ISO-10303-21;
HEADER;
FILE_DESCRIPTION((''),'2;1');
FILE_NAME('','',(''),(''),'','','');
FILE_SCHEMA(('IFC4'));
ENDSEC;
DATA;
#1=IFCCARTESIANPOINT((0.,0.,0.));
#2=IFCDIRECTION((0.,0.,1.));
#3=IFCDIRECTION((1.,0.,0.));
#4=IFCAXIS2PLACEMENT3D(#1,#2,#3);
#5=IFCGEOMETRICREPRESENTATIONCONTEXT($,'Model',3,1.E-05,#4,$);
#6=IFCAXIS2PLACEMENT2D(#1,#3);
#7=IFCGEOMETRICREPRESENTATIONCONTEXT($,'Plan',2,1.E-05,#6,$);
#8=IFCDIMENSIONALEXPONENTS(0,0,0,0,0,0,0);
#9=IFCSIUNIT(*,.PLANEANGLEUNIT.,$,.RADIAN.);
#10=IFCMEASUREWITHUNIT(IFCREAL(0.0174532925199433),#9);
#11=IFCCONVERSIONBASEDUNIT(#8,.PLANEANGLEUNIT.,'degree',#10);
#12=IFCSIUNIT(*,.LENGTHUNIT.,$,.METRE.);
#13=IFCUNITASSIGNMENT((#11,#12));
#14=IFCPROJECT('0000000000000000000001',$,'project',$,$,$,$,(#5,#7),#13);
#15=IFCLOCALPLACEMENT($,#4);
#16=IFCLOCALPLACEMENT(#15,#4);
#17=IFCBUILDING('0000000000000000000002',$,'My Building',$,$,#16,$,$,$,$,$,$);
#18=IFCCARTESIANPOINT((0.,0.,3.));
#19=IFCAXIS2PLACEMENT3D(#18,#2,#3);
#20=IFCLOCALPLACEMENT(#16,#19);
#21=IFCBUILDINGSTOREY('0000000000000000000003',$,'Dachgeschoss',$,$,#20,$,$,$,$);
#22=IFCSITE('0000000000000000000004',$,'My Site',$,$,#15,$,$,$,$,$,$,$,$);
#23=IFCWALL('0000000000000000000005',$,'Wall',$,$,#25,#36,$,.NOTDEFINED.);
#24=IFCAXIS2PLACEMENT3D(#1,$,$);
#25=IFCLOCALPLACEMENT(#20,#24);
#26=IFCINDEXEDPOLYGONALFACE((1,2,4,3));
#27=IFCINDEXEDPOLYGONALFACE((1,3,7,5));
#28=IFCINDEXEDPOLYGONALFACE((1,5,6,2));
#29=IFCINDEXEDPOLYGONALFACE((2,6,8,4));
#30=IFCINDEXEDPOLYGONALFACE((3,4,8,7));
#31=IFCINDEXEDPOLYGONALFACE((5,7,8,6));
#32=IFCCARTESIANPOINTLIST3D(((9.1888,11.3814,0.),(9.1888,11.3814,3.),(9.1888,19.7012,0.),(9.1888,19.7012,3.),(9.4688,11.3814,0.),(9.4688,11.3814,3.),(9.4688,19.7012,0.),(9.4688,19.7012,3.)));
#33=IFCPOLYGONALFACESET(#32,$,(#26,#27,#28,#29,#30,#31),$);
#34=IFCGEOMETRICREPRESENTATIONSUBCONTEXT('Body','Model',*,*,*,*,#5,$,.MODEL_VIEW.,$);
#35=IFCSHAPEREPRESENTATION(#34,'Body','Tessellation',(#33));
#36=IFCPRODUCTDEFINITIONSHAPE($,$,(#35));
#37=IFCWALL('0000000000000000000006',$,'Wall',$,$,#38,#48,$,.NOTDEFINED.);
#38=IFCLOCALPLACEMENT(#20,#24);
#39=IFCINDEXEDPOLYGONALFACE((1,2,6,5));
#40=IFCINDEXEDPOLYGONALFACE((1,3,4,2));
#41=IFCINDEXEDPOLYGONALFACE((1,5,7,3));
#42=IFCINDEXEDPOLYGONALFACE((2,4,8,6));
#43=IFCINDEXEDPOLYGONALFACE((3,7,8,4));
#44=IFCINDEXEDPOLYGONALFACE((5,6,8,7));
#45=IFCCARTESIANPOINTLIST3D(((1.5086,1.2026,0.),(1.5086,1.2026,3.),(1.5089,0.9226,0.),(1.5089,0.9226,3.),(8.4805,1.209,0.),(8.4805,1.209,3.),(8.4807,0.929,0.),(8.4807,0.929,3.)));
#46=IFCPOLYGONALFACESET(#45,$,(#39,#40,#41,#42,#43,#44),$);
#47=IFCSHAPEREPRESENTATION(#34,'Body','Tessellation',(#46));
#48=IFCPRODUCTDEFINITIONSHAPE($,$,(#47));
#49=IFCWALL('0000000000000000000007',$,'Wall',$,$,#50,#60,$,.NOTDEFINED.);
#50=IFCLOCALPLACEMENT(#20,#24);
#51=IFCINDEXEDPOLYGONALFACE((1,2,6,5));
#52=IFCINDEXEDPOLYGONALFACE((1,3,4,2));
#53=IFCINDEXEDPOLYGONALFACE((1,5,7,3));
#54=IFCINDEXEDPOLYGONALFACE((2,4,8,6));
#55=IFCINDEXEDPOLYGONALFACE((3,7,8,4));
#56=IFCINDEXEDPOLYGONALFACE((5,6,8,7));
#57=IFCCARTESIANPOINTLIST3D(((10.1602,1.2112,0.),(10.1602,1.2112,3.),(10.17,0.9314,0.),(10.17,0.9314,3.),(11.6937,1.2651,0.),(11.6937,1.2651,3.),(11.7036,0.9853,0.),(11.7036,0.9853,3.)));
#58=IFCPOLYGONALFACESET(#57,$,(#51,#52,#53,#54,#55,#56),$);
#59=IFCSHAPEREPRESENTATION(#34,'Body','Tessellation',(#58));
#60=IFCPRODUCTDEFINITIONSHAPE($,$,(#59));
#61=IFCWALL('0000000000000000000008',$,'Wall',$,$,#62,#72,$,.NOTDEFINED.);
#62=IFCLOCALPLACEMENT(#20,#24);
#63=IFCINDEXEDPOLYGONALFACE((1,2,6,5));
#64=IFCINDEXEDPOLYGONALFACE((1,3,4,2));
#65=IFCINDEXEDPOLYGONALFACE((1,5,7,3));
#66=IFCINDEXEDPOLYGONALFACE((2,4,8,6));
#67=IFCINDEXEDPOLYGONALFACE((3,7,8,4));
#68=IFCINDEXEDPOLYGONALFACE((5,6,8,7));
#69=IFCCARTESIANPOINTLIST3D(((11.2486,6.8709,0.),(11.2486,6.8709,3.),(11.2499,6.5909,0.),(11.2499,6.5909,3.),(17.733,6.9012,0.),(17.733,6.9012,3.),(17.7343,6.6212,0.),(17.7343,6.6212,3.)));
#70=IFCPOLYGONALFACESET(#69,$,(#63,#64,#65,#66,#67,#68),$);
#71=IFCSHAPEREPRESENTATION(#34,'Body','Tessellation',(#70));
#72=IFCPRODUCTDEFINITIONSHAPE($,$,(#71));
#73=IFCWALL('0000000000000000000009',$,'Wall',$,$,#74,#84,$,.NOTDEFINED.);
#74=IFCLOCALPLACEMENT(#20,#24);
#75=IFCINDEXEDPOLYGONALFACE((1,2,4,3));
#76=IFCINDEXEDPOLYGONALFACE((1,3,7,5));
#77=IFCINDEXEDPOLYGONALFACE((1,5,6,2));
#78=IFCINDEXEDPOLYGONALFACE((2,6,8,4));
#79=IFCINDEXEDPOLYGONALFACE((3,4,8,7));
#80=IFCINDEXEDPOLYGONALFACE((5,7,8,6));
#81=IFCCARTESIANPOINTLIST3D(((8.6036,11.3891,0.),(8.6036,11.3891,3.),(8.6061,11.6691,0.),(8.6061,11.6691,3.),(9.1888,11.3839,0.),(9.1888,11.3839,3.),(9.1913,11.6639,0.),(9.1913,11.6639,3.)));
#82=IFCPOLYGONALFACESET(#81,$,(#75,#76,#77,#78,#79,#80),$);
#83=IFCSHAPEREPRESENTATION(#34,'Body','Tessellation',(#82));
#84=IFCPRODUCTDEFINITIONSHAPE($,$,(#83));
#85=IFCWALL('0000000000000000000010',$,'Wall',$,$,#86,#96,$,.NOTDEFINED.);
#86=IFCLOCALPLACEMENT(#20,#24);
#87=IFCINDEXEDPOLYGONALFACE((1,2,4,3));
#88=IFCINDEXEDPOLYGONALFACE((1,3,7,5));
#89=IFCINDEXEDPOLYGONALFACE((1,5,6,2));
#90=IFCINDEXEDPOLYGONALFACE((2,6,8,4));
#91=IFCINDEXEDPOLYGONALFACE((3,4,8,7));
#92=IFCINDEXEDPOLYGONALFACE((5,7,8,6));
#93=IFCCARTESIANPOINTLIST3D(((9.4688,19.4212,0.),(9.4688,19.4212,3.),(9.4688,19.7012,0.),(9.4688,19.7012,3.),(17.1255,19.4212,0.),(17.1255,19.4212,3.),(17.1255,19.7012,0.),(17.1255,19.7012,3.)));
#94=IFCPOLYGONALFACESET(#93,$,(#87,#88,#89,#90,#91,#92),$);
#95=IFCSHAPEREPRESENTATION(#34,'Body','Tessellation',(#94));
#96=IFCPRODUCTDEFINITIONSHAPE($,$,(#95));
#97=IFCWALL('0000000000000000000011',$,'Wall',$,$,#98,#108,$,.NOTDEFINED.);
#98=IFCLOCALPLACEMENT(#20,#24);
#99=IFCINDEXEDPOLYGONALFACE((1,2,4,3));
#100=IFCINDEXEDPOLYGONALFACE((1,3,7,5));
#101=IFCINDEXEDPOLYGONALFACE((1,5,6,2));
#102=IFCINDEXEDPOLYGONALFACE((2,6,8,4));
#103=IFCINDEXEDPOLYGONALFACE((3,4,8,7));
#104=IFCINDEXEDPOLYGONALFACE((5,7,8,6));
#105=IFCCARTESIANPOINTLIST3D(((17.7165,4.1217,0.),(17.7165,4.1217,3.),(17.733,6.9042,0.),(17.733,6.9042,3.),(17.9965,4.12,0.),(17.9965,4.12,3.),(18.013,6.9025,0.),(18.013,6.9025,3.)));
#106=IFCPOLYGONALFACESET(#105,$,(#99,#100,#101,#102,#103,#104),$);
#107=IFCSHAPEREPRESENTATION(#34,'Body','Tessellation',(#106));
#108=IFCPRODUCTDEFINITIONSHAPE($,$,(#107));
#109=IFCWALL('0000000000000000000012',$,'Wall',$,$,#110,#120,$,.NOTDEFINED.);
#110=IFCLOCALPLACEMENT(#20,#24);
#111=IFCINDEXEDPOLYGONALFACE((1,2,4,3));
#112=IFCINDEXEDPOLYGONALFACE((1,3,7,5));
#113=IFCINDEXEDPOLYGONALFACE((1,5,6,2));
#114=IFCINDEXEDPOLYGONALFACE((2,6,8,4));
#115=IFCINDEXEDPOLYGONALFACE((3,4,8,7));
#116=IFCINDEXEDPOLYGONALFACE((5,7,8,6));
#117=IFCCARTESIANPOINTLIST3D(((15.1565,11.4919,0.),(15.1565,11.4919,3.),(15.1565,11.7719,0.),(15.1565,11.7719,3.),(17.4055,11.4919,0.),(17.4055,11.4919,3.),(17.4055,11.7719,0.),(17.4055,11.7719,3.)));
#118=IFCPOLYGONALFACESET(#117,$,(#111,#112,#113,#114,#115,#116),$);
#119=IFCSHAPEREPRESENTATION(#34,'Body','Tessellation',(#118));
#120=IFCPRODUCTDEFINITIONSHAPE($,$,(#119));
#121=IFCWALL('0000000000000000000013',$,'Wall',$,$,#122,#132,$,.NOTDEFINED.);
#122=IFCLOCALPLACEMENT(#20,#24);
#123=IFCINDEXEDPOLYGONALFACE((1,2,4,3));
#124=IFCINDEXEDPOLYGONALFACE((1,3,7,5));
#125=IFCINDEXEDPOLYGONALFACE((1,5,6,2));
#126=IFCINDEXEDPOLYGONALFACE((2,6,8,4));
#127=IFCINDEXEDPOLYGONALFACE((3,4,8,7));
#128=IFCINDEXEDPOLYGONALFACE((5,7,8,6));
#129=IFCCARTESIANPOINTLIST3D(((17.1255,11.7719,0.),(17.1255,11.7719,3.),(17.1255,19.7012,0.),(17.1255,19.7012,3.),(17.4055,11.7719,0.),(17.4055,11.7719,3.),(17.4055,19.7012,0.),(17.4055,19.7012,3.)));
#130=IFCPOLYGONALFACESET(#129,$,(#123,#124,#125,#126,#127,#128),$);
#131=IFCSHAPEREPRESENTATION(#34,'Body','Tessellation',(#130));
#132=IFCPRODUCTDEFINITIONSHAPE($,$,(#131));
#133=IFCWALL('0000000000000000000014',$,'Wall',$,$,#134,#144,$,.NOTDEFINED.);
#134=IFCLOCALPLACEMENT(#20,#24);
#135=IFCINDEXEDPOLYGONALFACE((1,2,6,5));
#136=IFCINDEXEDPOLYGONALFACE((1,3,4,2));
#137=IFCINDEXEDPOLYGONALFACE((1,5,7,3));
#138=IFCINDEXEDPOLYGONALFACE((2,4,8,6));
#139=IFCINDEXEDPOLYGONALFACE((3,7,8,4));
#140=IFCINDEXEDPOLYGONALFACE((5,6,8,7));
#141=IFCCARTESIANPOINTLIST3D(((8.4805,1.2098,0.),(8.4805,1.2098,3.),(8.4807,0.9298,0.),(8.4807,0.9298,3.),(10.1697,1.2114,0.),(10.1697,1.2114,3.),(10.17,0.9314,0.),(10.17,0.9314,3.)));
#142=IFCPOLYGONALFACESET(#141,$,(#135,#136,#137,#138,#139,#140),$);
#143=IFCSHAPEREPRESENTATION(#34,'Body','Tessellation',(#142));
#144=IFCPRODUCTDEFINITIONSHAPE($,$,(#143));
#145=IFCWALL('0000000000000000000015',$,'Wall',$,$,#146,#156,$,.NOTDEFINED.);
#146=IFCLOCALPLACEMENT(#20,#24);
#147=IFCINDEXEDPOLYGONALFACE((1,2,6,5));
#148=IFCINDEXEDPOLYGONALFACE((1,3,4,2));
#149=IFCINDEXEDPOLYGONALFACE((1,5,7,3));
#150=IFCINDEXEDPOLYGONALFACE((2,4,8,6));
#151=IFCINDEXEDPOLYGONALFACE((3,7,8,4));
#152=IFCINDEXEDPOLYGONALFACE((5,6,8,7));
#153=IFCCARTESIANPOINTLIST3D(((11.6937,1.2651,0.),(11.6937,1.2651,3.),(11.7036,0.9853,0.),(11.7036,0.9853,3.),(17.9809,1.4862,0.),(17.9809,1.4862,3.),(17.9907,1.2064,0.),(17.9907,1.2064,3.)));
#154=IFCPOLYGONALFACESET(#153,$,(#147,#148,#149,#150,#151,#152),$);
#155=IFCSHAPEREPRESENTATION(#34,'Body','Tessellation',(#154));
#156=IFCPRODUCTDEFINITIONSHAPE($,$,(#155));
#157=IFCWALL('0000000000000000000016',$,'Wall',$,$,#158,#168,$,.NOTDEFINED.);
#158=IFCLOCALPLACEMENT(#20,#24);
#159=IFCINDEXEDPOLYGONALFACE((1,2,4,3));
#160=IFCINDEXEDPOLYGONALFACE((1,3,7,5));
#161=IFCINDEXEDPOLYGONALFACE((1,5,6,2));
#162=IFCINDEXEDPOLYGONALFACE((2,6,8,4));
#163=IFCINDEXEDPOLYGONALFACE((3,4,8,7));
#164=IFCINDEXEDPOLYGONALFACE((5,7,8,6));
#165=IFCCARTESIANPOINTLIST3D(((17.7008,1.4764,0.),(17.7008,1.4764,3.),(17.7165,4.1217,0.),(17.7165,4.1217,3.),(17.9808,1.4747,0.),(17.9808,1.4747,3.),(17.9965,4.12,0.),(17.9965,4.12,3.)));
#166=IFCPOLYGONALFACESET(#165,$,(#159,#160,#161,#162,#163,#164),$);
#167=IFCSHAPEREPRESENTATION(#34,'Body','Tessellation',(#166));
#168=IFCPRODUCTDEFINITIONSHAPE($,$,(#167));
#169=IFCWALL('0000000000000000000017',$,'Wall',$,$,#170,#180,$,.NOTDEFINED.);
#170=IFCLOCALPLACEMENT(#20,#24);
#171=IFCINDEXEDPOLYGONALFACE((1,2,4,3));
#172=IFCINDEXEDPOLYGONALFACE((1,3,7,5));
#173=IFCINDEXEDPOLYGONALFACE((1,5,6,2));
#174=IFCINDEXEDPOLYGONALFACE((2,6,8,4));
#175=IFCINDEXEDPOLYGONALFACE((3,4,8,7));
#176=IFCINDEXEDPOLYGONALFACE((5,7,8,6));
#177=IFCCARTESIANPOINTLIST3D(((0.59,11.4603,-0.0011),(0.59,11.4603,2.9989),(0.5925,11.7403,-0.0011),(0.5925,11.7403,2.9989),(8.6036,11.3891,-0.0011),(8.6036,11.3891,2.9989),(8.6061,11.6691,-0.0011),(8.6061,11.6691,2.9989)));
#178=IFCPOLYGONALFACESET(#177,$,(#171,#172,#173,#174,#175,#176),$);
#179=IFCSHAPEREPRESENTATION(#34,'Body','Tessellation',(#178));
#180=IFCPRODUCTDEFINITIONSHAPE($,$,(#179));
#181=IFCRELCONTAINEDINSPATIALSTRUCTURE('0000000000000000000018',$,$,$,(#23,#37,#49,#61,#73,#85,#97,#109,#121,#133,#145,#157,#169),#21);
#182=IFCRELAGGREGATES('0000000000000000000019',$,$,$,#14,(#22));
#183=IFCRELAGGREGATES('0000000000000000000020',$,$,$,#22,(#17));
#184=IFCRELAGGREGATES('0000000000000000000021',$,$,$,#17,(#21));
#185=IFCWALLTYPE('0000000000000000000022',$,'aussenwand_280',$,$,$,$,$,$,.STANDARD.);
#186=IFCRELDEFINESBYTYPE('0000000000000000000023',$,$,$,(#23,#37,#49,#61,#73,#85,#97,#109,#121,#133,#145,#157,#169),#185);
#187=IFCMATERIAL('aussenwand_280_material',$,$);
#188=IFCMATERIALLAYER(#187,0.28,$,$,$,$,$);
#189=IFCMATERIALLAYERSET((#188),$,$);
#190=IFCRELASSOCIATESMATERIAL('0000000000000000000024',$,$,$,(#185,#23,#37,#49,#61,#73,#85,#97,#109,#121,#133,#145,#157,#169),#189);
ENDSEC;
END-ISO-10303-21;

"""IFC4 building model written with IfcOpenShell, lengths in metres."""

from ifc_helpers import new_model, entity, si_unit, converted_unit, frame, frame_2d, origin_with_axes, place, context, subcontext, project, spatial, indexed_curve, outline, extrude, material, layer, layer_set, layer_usage, type_object, element, save


model = new_model("IFC4")

# Units and contexts
model_context = context("Model", 3, precision=1e-05, world=origin_with_axes())
plan_context = context("Plan", 2, precision=1e-05, world=frame_2d((0.0, 0.0, 0.0), x_axis=(1.0, 0.0, 0.0)))
body_context = subcontext(model_context, "Body", "Model", "MODEL_VIEW")
ifc_project = project(units=[converted_unit("PLANEANGLEUNIT", "degree", entity("IfcReal", 0.0174532925199433), si_unit("PLANEANGLEUNIT", "RADIAN"), dimensions=[0, 0, 0, 0, 0, 0, 0]), si_unit("LENGTHUNIT", "METRE")], contexts=[model_context, plan_context])

# Site, building, storey
site_placement = place(None, origin_with_axes())
site = spatial("IfcSite", under=ifc_project, at=site_placement, Name="My Site")
building_placement = place(site_placement, origin_with_axes())
building = spatial("IfcBuilding", under=site, at=building_placement, Name="My Building")
storey_placement = place(building_placement, frame((0.0, 0.0, 3.0), z_axis=(0.0, 0.0, 1.0), x_axis=(1.0, 0.0, 0.0)))
storey = spatial("IfcBuildingStorey", under=building, at=storey_placement, Name="Dachgeschoss")

# Walls
ifc_material = material(Name="aussenwand_280_material")
ifc_layer = layer(ifc_material, 0.28)
ifc_layer_set = layer_set([ifc_layer])
ifc_layer_usage_1 = layer_usage(ifc_layer_set, "AXIS2", "POSITIVE", 0.0)
wall_type = type_object("IfcWallType", Name="aussenwand_280", PredefinedType="STANDARD", material=ifc_layer_set)
wall_1_placement = place(storey_placement, frame((9.1888, 19.7012, 0.0), z_axis=(0.0, 0.0, 1.0), x_axis=(0.0, -1.0, 0.0)))
element("IfcWall", 1, at=wall_1_placement, inside=storey, type_object=wall_type, material=ifc_layer_usage_1, Name="Wall", PredefinedType="NOTDEFINED", context=body_context, shape_type="SweptSolid", body=[
    extrude(outline(indexed_curve([(0.0, 0.0), (0.0, 0.28), (8.3198, 0.28), (8.3198, 0.0), (0.0, 0.0)], self_intersect=False)), origin_with_axes(), (0.0, 0.0, 1.0), 3.0),
])
ifc_layer_usage_2 = layer_usage(ifc_layer_set, "AXIS2", "POSITIVE", 0.0)
wall_2_placement = place(storey_placement, frame((1.5089, 0.9226, 0.0), z_axis=(0.0, 0.0, 1.0), x_axis=(1.0, 0.000923, 0.0)))
element("IfcWall", 2, at=wall_2_placement, inside=storey, type_object=wall_type, material=ifc_layer_usage_2, Name="Wall", PredefinedType="NOTDEFINED", context=body_context, shape_type="SweptSolid", body=[
    extrude(outline(indexed_curve([(0.0, 0.0), (0.0, 0.28), (6.9719, 0.28), (6.9719, 0.0), (0.0, 0.0)], self_intersect=False)), origin_with_axes(), (0.0, 0.0, 1.0), 3.0),
])
ifc_layer_usage_3 = layer_usage(ifc_layer_set, "AXIS2", "POSITIVE", 0.0)
wall_3_placement = place(storey_placement, frame((10.17, 0.9314, 0.0), z_axis=(0.0, 0.0, 1.0), x_axis=(0.999382, 0.035142, 0.0)))
element("IfcWall", 3, at=wall_3_placement, inside=storey, type_object=wall_type, material=ifc_layer_usage_3, Name="Wall", PredefinedType="NOTDEFINED", context=body_context, shape_type="SweptSolid", body=[
    extrude(outline(indexed_curve([(0.0, 0.0), (0.0, 0.28), (1.5345, 0.28), (1.5345, 0.0), (0.0, 0.0)], self_intersect=False)), origin_with_axes(), (0.0, 0.0, 1.0), 3.0),
])
ifc_layer_usage_4 = layer_usage(ifc_layer_set, "AXIS2", "POSITIVE", 0.0)
wall_4_placement = place(storey_placement, frame((17.733, 6.9012, 0.0), z_axis=(0.0, 0.0, 1.0), x_axis=(-0.999989, -0.004672, 0.0)))
element("IfcWall", 4, at=wall_4_placement, inside=storey, type_object=wall_type, material=ifc_layer_usage_4, Name="Wall", PredefinedType="NOTDEFINED", context=body_context, shape_type="SweptSolid", body=[
    extrude(outline(indexed_curve([(0.0, 0.0), (0.0, 0.28), (6.4845, 0.28), (6.4845, 0.0), (0.0, 0.0)], self_intersect=False)), origin_with_axes(), (0.0, 0.0, 1.0), 3.0),
])
ifc_layer_usage_5 = layer_usage(ifc_layer_set, "AXIS2", "POSITIVE", 0.0)
wall_5_placement = place(storey_placement, frame((9.1913, 11.6639, 0.0), z_axis=(0.0, 0.0, 1.0), x_axis=(-0.999961, 0.008884, 0.0)))
element("IfcWall", 5, at=wall_5_placement, inside=storey, type_object=wall_type, material=ifc_layer_usage_5, Name="Wall", PredefinedType="NOTDEFINED", context=body_context, shape_type="SweptSolid", body=[
    extrude(outline(indexed_curve([(0.0, 0.0), (0.0, 0.28), (0.5852, 0.28), (0.5852, 0.0), (0.0, 0.0)], self_intersect=False)), origin_with_axes(), (0.0, 0.0, 1.0), 3.0),
])
ifc_layer_usage_6 = layer_usage(ifc_layer_set, "AXIS2", "POSITIVE", 0.0)
wall_6_placement = place(storey_placement, frame((9.4688, 19.4212, 0.0), z_axis=(0.0, 0.0, 1.0), x_axis=(1.0, 0.0, 0.0)))
element("IfcWall", 6, at=wall_6_placement, inside=storey, type_object=wall_type, material=ifc_layer_usage_6, Name="Wall", PredefinedType="NOTDEFINED", context=body_context, shape_type="SweptSolid", body=[
    extrude(outline(indexed_curve([(0.0, 0.0), (0.0, 0.28), (7.6567, 0.28), (7.6567, 0.0), (0.0, 0.0)], self_intersect=False)), origin_with_axes(), (0.0, 0.0, 1.0), 3.0),
])
ifc_layer_usage_7 = layer_usage(ifc_layer_set, "AXIS2", "POSITIVE", 0.0)
wall_7_placement = place(storey_placement, frame((17.733, 6.9042, 0.0), z_axis=(0.0, 0.0, 1.0), x_axis=(-0.005929, -0.999982, 0.0)))
element("IfcWall", 7, at=wall_7_placement, inside=storey, type_object=wall_type, material=ifc_layer_usage_7, Name="Wall", PredefinedType="NOTDEFINED", context=body_context, shape_type="SweptSolid", body=[
    extrude(outline(indexed_curve([(0.0, 0.0), (0.0, 0.28), (2.7826, 0.28), (2.7826, 0.0), (0.0, 0.0)], self_intersect=False)), origin_with_axes(), (0.0, 0.0, 1.0), 3.0),
])
ifc_layer_usage_8 = layer_usage(ifc_layer_set, "AXIS2", "POSITIVE", 0.0)
wall_8_placement = place(storey_placement, frame((15.1565, 11.4919, 0.0), z_axis=(0.0, 0.0, 1.0), x_axis=(1.0, 0.0, 0.0)))
element("IfcWall", 8, at=wall_8_placement, inside=storey, type_object=wall_type, material=ifc_layer_usage_8, Name="Wall", PredefinedType="NOTDEFINED", context=body_context, shape_type="SweptSolid", body=[
    extrude(outline(indexed_curve([(0.0, 0.0), (0.0, 0.28), (2.249, 0.28), (2.249, 0.0), (0.0, 0.0)], self_intersect=False)), origin_with_axes(), (0.0, 0.0, 1.0), 3.0),
])
ifc_layer_usage_9 = layer_usage(ifc_layer_set, "AXIS2", "POSITIVE", 0.0)
wall_9_placement = place(storey_placement, frame((17.1255, 19.7012, 0.0), z_axis=(0.0, 0.0, 1.0), x_axis=(0.0, -1.0, 0.0)))
element("IfcWall", 9, at=wall_9_placement, inside=storey, type_object=wall_type, material=ifc_layer_usage_9, Name="Wall", PredefinedType="NOTDEFINED", context=body_context, shape_type="SweptSolid", body=[
    extrude(outline(indexed_curve([(0.0, 0.0), (0.0, 0.28), (7.9293, 0.28), (7.9293, 0.0), (0.0, 0.0)], self_intersect=False)), origin_with_axes(), (0.0, 0.0, 1.0), 3.0),
])
ifc_layer_usage_10 = layer_usage(ifc_layer_set, "AXIS2", "POSITIVE", 0.0)
wall_10_placement = place(storey_placement, frame((8.4807, 0.9298, 0.0), z_axis=(0.0, 0.0, 1.0), x_axis=(1.0, 0.000923, 0.0)))
element("IfcWall", 10, at=wall_10_placement, inside=storey, type_object=wall_type, material=ifc_layer_usage_10, Name="Wall", PredefinedType="NOTDEFINED", context=body_context, shape_type="SweptSolid", body=[
    extrude(outline(indexed_curve([(0.0, 0.0), (0.0, 0.28), (1.6893, 0.28), (1.6893, 0.0), (0.0, 0.0)], self_intersect=False)), origin_with_axes(), (0.0, 0.0, 1.0), 3.0),
])
ifc_layer_usage_11 = layer_usage(ifc_layer_set, "AXIS2", "POSITIVE", 0.0)
wall_11_placement = place(storey_placement, frame((11.7036, 0.9853, 0.0), z_axis=(0.0, 0.0, 1.0), x_axis=(0.999382, 0.035142, 0.0)))
element("IfcWall", 11, at=wall_11_placement, inside=storey, type_object=wall_type, material=ifc_layer_usage_11, Name="Wall", PredefinedType="NOTDEFINED", context=body_context, shape_type="SweptSolid", body=[
    extrude(outline(indexed_curve([(0.0, 0.0), (0.0, 0.28), (6.291, 0.28), (6.291, 0.0), (0.0, 0.0)], self_intersect=False)), origin_with_axes(), (0.0, 0.0, 1.0), 3.0),
])
ifc_layer_usage_12 = layer_usage(ifc_layer_set, "AXIS2", "POSITIVE", 0.0)
wall_12_placement = place(storey_placement, frame((17.7165, 4.1217, 0.0), z_axis=(0.0, 0.0, 1.0), x_axis=(-0.005929, -0.999982, 0.0)))
element("IfcWall", 12, at=wall_12_placement, inside=storey, type_object=wall_type, material=ifc_layer_usage_12, Name="Wall", PredefinedType="NOTDEFINED", context=body_context, shape_type="SweptSolid", body=[
    extrude(outline(indexed_curve([(0.0, 0.0), (0.0, 0.28), (2.6453, 0.28), (2.6453, 0.0), (0.0, 0.0)], self_intersect=False)), origin_with_axes(), (0.0, 0.0, 1.0), 3.0),
])
ifc_layer_usage_13 = layer_usage(ifc_layer_set, "AXIS2", "POSITIVE", 0.0)
wall_13_placement = place(storey_placement, frame((8.6061, 11.6691, -0.0011), z_axis=(0.0, 0.0, 1.0), x_axis=(-0.999961, 0.008884, 0.0)))
element("IfcWall", 13, at=wall_13_placement, inside=storey, type_object=wall_type, material=ifc_layer_usage_13, Name="Wall", PredefinedType="NOTDEFINED", context=body_context, shape_type="SweptSolid", body=[
    extrude(outline(indexed_curve([(0.0, 0.0), (0.0, 0.28), (8.0139, 0.28), (8.0139, 0.0), (0.0, 0.0)], self_intersect=False)), origin_with_axes(), (0.0, 0.0, 1.0), 3.0),
])

save(model, "model.ifc")
